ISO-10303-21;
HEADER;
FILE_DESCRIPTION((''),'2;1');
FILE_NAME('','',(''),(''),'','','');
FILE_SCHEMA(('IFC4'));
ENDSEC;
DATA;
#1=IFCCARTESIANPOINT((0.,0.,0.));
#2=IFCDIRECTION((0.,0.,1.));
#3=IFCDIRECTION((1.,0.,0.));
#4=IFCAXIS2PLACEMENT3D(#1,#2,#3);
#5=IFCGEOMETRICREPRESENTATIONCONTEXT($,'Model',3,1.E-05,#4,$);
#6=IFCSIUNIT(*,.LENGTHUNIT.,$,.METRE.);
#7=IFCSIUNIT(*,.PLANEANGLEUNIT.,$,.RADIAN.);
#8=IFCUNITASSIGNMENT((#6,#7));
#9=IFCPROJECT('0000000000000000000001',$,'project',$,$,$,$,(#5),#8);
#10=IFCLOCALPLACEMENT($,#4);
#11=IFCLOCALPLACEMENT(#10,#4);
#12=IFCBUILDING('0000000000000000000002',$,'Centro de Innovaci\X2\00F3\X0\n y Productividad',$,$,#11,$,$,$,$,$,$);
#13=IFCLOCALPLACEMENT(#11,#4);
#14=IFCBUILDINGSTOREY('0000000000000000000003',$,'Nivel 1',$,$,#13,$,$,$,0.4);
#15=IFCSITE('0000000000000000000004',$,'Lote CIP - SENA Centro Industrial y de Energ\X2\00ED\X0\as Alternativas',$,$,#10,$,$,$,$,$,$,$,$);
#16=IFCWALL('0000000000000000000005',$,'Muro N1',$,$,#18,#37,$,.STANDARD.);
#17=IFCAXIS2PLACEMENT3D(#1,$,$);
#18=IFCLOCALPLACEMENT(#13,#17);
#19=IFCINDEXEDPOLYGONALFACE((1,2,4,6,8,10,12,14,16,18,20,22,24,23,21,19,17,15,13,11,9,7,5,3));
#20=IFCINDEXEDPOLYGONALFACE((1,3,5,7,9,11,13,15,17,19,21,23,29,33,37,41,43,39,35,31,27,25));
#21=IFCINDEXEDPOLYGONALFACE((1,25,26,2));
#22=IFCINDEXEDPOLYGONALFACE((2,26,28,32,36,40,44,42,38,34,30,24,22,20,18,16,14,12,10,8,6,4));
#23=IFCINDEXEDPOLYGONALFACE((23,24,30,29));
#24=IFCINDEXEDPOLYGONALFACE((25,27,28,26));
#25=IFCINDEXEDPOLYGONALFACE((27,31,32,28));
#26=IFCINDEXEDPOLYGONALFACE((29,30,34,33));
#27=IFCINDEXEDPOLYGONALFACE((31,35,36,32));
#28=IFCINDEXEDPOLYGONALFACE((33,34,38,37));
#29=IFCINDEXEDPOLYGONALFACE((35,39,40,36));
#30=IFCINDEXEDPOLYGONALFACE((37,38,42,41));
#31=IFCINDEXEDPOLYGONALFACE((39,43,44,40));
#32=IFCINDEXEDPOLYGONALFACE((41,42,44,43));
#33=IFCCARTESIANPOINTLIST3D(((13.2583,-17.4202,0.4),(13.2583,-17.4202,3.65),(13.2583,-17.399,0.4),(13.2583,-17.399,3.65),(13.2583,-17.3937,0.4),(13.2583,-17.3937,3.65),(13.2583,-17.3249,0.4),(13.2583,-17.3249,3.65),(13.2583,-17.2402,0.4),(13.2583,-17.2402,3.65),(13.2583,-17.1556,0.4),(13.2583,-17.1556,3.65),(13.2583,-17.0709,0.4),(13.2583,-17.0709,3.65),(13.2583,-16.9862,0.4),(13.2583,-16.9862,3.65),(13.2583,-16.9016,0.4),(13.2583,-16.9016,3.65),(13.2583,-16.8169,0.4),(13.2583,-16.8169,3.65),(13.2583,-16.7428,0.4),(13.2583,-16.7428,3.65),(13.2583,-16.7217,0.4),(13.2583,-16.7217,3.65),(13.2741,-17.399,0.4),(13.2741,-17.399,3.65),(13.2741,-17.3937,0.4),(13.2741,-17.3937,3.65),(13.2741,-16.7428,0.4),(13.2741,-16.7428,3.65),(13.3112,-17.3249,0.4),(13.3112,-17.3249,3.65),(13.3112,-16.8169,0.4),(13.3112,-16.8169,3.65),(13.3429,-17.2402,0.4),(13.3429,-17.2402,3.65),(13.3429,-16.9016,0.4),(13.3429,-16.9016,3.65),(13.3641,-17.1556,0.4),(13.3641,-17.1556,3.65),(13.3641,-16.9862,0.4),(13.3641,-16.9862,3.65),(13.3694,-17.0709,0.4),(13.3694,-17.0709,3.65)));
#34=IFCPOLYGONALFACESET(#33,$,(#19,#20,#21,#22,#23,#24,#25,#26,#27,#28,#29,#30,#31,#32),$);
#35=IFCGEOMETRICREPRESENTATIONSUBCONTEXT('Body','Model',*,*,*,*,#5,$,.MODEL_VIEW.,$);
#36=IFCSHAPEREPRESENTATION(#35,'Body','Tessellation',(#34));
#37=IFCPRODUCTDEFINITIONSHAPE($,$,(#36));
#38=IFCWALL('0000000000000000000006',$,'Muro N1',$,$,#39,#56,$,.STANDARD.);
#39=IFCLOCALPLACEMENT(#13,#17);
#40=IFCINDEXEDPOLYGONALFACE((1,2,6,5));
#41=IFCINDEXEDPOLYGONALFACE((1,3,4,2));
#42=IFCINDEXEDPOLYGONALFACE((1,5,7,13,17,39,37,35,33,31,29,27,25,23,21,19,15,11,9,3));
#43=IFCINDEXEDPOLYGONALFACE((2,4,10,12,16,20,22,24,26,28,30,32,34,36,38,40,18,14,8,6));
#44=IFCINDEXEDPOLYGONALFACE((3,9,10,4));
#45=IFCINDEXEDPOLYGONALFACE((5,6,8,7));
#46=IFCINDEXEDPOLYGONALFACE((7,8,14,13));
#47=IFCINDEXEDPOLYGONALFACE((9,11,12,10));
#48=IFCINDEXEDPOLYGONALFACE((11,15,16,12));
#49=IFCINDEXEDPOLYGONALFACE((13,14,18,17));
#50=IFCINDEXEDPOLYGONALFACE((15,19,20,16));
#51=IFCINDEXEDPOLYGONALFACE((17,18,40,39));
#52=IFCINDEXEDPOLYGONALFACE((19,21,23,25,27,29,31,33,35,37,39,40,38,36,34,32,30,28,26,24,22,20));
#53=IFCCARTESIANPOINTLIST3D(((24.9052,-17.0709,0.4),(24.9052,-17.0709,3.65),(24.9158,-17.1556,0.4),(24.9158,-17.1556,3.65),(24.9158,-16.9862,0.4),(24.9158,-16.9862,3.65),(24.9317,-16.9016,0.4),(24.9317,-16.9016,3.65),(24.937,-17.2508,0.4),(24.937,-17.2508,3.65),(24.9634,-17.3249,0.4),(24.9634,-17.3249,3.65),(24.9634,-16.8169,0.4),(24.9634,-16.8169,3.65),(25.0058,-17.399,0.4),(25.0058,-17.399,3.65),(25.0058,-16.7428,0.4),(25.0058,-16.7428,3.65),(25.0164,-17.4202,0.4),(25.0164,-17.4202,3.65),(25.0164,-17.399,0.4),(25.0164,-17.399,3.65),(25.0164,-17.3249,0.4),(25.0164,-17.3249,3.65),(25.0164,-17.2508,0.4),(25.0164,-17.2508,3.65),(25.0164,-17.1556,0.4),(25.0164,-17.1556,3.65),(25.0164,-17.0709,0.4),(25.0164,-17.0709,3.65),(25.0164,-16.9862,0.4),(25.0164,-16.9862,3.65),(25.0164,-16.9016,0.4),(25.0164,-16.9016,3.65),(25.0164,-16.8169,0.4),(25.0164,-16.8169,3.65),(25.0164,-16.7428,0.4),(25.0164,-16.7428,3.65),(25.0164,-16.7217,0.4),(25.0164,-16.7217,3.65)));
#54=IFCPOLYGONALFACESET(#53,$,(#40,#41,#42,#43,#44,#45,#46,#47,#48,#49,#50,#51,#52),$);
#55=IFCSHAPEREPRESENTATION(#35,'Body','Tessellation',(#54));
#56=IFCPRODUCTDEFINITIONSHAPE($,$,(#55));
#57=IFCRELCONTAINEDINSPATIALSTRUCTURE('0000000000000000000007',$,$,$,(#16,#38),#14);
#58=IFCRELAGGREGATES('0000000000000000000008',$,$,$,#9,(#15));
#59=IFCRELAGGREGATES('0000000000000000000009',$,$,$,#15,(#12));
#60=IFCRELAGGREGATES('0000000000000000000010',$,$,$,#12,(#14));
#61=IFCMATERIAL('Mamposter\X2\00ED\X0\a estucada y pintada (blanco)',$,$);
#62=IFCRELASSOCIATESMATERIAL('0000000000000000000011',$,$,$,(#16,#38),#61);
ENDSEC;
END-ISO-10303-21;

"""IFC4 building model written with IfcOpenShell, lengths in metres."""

from ifc_helpers import new_model, si_unit, frame, origin_with_axes, place, context, subcontext, project, spatial, polyline, outline, extrude, material, element, save


model = new_model("IFC4")

# Units and contexts
model_context = context("Model", 3, precision=1e-05, world=origin_with_axes())
body_context = subcontext(model_context, "Body", "Model", "MODEL_VIEW")
ifc_project = project(units=[si_unit("LENGTHUNIT", "METRE"), si_unit("PLANEANGLEUNIT", "RADIAN")], contexts=[model_context])

# Site, building, storey
site_placement = place(None, origin_with_axes())
site = spatial("IfcSite", under=ifc_project, at=site_placement, Name="Lote CIP - SENA Centro Industrial y de Energías Alternativas")
building_placement = place(site_placement, origin_with_axes())
building = spatial("IfcBuilding", under=site, at=building_placement, Name="Centro de Innovación y Productividad")
storey_placement = place(building_placement, origin_with_axes())
storey = spatial("IfcBuildingStorey", under=building, at=storey_placement, Name="Nivel 1", Elevation=0.4)

# Walls
ifc_material = material(Name="Mampostería estucada y pintada (blanco)")
wall_1_placement = place(storey_placement, origin_with_axes())
element("IfcWall", 1, at=wall_1_placement, inside=storey, material=ifc_material, Name="Muro N1", PredefinedType="STANDARD", context=body_context, shape_type="SweptSolid", body=[
    extrude(outline(polyline([(13.2583, -17.0709), (13.2583, -16.9862), (13.2583, -16.9016), (13.2583, -16.8169), (13.2583, -16.7428), (13.2583, -16.7217), (13.2741, -16.7428), (13.3112, -16.8169), (13.3429, -16.9016), (13.3641, -16.9862), (13.3694, -17.0709), (13.3641, -17.1556), (13.3429, -17.2402), (13.3112, -17.3249), (13.2741, -17.3937), (13.2741, -17.399), (13.2583, -17.4202), (13.2583, -17.399), (13.2583, -17.3937), (13.2583, -17.3249), (13.2583, -17.2402), (13.2583, -17.1556), (13.2583, -17.0709)])), frame((0.0, 0.0, 0.4)), (0.0, 0.0, 1.0), 3.25),
])
wall_2_placement = place(storey_placement, origin_with_axes())
element("IfcWall", 2, at=wall_2_placement, inside=storey, material=ifc_material, Name="Muro N1", PredefinedType="STANDARD", context=body_context, shape_type="SweptSolid", body=[
    extrude(outline(polyline([(25.0164, -17.399), (25.0164, -17.4202), (25.0058, -17.399), (24.9634, -17.3249), (24.937, -17.2508), (24.9158, -17.1556), (24.9052, -17.0709), (24.9158, -16.9862), (24.9317, -16.9016), (24.9634, -16.8169), (25.0058, -16.7428), (25.0164, -16.7217), (25.0164, -16.7428), (25.0164, -16.8169), (25.0164, -16.9016), (25.0164, -16.9862), (25.0164, -17.0709), (25.0164, -17.1556), (25.0164, -17.2508), (25.0164, -17.3249), (25.0164, -17.399)])), frame((0.0, 0.0, 0.4)), (0.0, 0.0, 1.0), 3.25),
])

save(model, "model.ifc")
